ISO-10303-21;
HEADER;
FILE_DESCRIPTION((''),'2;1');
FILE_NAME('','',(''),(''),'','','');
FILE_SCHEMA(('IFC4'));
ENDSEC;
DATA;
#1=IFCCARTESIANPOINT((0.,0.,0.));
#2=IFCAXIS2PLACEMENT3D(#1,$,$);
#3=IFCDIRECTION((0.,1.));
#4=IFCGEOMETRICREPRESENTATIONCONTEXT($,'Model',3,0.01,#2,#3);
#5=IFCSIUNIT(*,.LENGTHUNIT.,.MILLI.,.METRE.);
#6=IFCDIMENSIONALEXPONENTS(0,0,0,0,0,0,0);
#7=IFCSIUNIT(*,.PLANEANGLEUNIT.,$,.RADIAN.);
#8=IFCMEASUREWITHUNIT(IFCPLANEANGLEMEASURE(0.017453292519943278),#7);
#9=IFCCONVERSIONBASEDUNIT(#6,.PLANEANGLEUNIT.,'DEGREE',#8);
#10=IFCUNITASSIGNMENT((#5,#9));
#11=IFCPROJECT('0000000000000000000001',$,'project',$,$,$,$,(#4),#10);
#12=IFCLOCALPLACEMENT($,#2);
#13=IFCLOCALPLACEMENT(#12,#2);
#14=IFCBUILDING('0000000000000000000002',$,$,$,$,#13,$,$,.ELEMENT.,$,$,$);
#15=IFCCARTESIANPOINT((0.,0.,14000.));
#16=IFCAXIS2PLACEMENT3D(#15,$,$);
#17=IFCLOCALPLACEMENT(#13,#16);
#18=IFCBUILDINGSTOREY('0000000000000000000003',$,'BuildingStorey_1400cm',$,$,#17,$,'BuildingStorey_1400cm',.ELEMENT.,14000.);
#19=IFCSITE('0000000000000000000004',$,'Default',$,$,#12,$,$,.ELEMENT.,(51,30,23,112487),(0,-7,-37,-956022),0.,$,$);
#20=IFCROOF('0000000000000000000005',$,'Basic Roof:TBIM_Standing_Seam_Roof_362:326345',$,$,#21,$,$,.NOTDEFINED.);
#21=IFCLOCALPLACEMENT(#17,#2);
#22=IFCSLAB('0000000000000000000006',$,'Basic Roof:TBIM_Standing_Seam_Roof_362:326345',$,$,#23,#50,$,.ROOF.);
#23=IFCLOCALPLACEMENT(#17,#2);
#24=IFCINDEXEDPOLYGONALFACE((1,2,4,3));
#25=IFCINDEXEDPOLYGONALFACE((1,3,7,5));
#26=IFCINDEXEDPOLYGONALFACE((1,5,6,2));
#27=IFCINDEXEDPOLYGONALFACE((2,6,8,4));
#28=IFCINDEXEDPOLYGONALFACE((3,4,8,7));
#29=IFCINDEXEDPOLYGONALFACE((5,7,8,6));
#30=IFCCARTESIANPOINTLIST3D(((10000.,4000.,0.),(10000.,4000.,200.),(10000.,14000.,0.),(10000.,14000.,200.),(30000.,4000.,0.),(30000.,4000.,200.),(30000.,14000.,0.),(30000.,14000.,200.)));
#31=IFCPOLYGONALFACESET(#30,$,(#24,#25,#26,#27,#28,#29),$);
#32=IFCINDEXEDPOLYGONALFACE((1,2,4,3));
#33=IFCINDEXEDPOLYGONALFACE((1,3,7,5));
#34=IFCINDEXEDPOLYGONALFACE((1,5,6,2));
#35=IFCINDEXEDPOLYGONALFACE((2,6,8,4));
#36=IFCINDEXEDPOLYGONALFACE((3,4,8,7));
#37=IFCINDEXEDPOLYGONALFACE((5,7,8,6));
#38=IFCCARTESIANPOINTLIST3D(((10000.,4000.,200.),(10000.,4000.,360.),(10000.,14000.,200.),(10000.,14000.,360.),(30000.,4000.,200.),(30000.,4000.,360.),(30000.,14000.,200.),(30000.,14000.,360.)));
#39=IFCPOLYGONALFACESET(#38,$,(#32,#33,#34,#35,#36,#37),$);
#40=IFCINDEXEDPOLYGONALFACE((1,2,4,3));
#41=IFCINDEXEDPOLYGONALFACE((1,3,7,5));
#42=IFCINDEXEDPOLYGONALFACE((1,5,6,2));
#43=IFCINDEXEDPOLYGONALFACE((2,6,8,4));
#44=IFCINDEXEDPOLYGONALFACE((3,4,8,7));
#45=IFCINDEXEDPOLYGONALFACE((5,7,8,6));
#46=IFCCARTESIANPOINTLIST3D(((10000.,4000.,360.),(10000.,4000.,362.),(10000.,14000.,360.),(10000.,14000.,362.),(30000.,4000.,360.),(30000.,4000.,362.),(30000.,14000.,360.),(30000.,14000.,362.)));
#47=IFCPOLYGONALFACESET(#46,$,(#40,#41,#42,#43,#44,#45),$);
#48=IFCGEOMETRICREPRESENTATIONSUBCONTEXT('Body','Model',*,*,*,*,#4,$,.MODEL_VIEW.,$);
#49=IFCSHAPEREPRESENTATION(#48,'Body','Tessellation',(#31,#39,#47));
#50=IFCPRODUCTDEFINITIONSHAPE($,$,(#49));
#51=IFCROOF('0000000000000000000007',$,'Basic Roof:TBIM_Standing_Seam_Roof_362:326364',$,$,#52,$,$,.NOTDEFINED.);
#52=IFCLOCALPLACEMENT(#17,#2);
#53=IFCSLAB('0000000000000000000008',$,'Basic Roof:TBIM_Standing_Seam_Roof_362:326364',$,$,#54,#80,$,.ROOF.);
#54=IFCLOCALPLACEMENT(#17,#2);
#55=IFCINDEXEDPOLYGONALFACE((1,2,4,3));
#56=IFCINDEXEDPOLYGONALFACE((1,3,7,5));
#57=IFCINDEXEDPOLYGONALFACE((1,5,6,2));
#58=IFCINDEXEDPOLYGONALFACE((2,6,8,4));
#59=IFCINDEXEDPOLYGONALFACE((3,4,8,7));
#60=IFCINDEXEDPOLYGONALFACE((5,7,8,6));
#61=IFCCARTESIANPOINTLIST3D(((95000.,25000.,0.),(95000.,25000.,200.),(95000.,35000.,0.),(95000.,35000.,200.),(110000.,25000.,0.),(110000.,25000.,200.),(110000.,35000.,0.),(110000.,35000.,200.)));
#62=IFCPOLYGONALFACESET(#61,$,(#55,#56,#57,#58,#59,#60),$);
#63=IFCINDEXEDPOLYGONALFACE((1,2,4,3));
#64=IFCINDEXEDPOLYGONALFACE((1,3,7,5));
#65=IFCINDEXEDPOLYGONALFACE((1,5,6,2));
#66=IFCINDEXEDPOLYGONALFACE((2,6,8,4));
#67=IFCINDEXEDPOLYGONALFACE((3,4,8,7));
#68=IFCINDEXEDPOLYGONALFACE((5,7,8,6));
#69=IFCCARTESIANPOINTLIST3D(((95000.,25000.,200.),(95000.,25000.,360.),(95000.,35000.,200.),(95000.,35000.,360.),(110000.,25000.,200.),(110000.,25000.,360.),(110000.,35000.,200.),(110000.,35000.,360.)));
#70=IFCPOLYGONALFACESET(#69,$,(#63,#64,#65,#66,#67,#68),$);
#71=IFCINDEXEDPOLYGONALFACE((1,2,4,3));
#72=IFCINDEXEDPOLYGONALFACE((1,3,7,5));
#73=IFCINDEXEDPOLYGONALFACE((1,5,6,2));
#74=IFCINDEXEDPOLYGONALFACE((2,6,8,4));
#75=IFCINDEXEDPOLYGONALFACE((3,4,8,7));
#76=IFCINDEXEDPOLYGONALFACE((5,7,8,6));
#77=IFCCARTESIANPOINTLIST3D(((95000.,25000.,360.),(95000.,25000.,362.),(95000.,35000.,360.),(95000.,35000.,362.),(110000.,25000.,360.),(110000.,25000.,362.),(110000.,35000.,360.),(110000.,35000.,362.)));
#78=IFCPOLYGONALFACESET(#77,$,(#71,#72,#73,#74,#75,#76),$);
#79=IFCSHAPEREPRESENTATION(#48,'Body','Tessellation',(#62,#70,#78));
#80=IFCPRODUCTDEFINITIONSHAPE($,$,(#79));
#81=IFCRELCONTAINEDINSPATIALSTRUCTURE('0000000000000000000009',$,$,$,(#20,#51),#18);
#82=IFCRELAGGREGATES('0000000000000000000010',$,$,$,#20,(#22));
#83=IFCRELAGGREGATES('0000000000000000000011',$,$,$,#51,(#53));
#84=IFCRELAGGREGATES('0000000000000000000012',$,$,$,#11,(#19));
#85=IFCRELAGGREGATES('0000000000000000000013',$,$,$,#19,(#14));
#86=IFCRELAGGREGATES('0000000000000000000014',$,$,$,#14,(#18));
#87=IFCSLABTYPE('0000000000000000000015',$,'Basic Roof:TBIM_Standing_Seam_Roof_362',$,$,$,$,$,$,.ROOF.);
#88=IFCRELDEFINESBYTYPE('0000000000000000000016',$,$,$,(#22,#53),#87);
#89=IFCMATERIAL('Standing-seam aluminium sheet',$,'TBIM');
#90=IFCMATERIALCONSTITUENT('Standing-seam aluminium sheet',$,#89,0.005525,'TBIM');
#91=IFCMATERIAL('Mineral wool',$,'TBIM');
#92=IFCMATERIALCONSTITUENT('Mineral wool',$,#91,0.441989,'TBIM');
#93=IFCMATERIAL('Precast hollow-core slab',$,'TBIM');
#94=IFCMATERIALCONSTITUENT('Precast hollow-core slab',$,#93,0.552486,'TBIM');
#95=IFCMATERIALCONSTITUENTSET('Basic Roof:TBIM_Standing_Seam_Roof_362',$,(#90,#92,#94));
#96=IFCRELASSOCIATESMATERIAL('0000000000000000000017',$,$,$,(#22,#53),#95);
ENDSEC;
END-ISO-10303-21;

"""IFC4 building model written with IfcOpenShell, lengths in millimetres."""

from ifc_helpers import new_model, entity, si_unit, converted_unit, direction, frame, origin, place, context, subcontext, project, spatial, indexed_curve, outline, extrude, material, constituent, constituent_set, type_object, element, aggregate, save


model = new_model("IFC4")

# Units and contexts
model_context = context("Model", 3, precision=0.01, world=origin(), true_north=direction((0.0, 1.0)))
body_context = subcontext(model_context, "Body", "Model", "MODEL_VIEW")
ifc_project = project(units=[si_unit("LENGTHUNIT", "METRE", prefix="MILLI"), converted_unit("PLANEANGLEUNIT", "DEGREE", entity("IfcPlaneAngleMeasure", 0.017453292519943278), si_unit("PLANEANGLEUNIT", "RADIAN"), dimensions=[0, 0, 0, 0, 0, 0, 0])], contexts=[model_context])

# Site, building, storey
site_placement = place(None, origin())
site = spatial("IfcSite", under=ifc_project, at=site_placement, Name="Default", CompositionType="ELEMENT", RefLatitude=(51, 30, 23, 112487), RefLongitude=(0, -7, -37, -956022), RefElevation=0.0)
building_placement = place(site_placement, origin())
building = spatial("IfcBuilding", under=site, at=building_placement, CompositionType="ELEMENT")
storey_placement = place(building_placement, frame((0.0, 0.0, 14000.0)))
storey = spatial("IfcBuildingStorey", under=building, at=storey_placement, Name="BuildingStorey_1400cm", LongName="BuildingStorey_1400cm", CompositionType="ELEMENT", Elevation=14000.0)

# Roofs, slabs
roof_1_placement = place(storey_placement, frame((10000.0, 4000.0, 0.0)))
roof_1 = element("IfcRoof", 1, at=roof_1_placement, inside=storey, Name="Basic Roof:TBIM_Standing_Seam_Roof_362:326345", PredefinedType="NOTDEFINED")
ifc_material_1 = material(Name="Standing-seam aluminium sheet", Category="TBIM")
ifc_constituent_1 = constituent(ifc_material_1, Name="Standing-seam aluminium sheet", Category="TBIM", fraction=0.005525)
ifc_material_2 = material(Name="Mineral wool", Category="TBIM")
ifc_constituent_2 = constituent(ifc_material_2, Name="Mineral wool", Category="TBIM", fraction=0.441989)
ifc_material_3 = material(Name="Precast hollow-core slab", Category="TBIM")
ifc_constituent_3 = constituent(ifc_material_3, Name="Precast hollow-core slab", Category="TBIM", fraction=0.552486)
ifc_constituent_set = constituent_set(constituents=[ifc_constituent_1, ifc_constituent_2, ifc_constituent_3], Name="Basic Roof:TBIM_Standing_Seam_Roof_362")
slab_type = type_object("IfcSlabType", Name="Basic Roof:TBIM_Standing_Seam_Roof_362", PredefinedType="ROOF")
slab_1_placement = place(roof_1_placement, origin())
slab_1 = element("IfcSlab", 2, at=slab_1_placement, type_object=slab_type, material=ifc_constituent_set, Name="Basic Roof:TBIM_Standing_Seam_Roof_362:326345", PredefinedType="ROOF", context=body_context, shape_type="SweptSolid", body=[
    extrude(outline(indexed_curve([(-10000.0, 5000.0), (-10000.0, -5000.0), (10000.0, -5000.0), (10000.0, 5000.0), (-10000.0, 5000.0)], self_intersect=False)), frame((10000.0, 5000.0, 0.0)), (0.0, 0.0, 1.0), 200.0),
    extrude(outline(indexed_curve([(-10000.0, 5000.0), (-10000.0, -5000.0), (10000.0, -5000.0), (10000.0, 5000.0), (-10000.0, 5000.0)], self_intersect=False)), frame((10000.0, 5000.0, 200.0)), (0.0, 0.0, 1.0), 160.0),
    extrude(outline(indexed_curve([(-10000.0, 5000.0), (-10000.0, -5000.0), (10000.0, -5000.0), (10000.0, 5000.0), (-10000.0, 5000.0)], self_intersect=False)), frame((10000.0, 5000.0, 360.0)), (0.0, 0.0, 1.0), 2.0),
])
aggregate(roof_1, [slab_1])
roof_2_placement = place(storey_placement, frame((95000.0, 25000.0, 0.0)))
roof_2 = element("IfcRoof", 3, at=roof_2_placement, inside=storey, Name="Basic Roof:TBIM_Standing_Seam_Roof_362:326364", PredefinedType="NOTDEFINED")
slab_2_placement = place(roof_2_placement, origin())
slab_2 = element("IfcSlab", 4, at=slab_2_placement, type_object=slab_type, material=ifc_constituent_set, Name="Basic Roof:TBIM_Standing_Seam_Roof_362:326364", PredefinedType="ROOF", context=body_context, shape_type="SweptSolid", body=[
    extrude(outline(indexed_curve([(-7500.0, 5000.0), (-7500.0, -5000.0), (7500.0, -5000.0), (7500.0, 5000.0), (-7500.0, 5000.0)], self_intersect=False)), frame((7500.0, 5000.0, 0.0)), (0.0, 0.0, 1.0), 200.0),
    extrude(outline(indexed_curve([(-7500.0, 5000.0), (-7500.0, -5000.0), (7500.0, -5000.0), (7500.0, 5000.0), (-7500.0, 5000.0)], self_intersect=False)), frame((7500.0, 5000.0, 200.0)), (0.0, 0.0, 1.0), 160.0),
    extrude(outline(indexed_curve([(-7500.0, 5000.0), (-7500.0, -5000.0), (7500.0, -5000.0), (7500.0, 5000.0), (-7500.0, 5000.0)], self_intersect=False)), frame((7500.0, 5000.0, 360.0)), (0.0, 0.0, 1.0), 2.0),
])
aggregate(roof_2, [slab_2])

save(model, "model.ifc")
